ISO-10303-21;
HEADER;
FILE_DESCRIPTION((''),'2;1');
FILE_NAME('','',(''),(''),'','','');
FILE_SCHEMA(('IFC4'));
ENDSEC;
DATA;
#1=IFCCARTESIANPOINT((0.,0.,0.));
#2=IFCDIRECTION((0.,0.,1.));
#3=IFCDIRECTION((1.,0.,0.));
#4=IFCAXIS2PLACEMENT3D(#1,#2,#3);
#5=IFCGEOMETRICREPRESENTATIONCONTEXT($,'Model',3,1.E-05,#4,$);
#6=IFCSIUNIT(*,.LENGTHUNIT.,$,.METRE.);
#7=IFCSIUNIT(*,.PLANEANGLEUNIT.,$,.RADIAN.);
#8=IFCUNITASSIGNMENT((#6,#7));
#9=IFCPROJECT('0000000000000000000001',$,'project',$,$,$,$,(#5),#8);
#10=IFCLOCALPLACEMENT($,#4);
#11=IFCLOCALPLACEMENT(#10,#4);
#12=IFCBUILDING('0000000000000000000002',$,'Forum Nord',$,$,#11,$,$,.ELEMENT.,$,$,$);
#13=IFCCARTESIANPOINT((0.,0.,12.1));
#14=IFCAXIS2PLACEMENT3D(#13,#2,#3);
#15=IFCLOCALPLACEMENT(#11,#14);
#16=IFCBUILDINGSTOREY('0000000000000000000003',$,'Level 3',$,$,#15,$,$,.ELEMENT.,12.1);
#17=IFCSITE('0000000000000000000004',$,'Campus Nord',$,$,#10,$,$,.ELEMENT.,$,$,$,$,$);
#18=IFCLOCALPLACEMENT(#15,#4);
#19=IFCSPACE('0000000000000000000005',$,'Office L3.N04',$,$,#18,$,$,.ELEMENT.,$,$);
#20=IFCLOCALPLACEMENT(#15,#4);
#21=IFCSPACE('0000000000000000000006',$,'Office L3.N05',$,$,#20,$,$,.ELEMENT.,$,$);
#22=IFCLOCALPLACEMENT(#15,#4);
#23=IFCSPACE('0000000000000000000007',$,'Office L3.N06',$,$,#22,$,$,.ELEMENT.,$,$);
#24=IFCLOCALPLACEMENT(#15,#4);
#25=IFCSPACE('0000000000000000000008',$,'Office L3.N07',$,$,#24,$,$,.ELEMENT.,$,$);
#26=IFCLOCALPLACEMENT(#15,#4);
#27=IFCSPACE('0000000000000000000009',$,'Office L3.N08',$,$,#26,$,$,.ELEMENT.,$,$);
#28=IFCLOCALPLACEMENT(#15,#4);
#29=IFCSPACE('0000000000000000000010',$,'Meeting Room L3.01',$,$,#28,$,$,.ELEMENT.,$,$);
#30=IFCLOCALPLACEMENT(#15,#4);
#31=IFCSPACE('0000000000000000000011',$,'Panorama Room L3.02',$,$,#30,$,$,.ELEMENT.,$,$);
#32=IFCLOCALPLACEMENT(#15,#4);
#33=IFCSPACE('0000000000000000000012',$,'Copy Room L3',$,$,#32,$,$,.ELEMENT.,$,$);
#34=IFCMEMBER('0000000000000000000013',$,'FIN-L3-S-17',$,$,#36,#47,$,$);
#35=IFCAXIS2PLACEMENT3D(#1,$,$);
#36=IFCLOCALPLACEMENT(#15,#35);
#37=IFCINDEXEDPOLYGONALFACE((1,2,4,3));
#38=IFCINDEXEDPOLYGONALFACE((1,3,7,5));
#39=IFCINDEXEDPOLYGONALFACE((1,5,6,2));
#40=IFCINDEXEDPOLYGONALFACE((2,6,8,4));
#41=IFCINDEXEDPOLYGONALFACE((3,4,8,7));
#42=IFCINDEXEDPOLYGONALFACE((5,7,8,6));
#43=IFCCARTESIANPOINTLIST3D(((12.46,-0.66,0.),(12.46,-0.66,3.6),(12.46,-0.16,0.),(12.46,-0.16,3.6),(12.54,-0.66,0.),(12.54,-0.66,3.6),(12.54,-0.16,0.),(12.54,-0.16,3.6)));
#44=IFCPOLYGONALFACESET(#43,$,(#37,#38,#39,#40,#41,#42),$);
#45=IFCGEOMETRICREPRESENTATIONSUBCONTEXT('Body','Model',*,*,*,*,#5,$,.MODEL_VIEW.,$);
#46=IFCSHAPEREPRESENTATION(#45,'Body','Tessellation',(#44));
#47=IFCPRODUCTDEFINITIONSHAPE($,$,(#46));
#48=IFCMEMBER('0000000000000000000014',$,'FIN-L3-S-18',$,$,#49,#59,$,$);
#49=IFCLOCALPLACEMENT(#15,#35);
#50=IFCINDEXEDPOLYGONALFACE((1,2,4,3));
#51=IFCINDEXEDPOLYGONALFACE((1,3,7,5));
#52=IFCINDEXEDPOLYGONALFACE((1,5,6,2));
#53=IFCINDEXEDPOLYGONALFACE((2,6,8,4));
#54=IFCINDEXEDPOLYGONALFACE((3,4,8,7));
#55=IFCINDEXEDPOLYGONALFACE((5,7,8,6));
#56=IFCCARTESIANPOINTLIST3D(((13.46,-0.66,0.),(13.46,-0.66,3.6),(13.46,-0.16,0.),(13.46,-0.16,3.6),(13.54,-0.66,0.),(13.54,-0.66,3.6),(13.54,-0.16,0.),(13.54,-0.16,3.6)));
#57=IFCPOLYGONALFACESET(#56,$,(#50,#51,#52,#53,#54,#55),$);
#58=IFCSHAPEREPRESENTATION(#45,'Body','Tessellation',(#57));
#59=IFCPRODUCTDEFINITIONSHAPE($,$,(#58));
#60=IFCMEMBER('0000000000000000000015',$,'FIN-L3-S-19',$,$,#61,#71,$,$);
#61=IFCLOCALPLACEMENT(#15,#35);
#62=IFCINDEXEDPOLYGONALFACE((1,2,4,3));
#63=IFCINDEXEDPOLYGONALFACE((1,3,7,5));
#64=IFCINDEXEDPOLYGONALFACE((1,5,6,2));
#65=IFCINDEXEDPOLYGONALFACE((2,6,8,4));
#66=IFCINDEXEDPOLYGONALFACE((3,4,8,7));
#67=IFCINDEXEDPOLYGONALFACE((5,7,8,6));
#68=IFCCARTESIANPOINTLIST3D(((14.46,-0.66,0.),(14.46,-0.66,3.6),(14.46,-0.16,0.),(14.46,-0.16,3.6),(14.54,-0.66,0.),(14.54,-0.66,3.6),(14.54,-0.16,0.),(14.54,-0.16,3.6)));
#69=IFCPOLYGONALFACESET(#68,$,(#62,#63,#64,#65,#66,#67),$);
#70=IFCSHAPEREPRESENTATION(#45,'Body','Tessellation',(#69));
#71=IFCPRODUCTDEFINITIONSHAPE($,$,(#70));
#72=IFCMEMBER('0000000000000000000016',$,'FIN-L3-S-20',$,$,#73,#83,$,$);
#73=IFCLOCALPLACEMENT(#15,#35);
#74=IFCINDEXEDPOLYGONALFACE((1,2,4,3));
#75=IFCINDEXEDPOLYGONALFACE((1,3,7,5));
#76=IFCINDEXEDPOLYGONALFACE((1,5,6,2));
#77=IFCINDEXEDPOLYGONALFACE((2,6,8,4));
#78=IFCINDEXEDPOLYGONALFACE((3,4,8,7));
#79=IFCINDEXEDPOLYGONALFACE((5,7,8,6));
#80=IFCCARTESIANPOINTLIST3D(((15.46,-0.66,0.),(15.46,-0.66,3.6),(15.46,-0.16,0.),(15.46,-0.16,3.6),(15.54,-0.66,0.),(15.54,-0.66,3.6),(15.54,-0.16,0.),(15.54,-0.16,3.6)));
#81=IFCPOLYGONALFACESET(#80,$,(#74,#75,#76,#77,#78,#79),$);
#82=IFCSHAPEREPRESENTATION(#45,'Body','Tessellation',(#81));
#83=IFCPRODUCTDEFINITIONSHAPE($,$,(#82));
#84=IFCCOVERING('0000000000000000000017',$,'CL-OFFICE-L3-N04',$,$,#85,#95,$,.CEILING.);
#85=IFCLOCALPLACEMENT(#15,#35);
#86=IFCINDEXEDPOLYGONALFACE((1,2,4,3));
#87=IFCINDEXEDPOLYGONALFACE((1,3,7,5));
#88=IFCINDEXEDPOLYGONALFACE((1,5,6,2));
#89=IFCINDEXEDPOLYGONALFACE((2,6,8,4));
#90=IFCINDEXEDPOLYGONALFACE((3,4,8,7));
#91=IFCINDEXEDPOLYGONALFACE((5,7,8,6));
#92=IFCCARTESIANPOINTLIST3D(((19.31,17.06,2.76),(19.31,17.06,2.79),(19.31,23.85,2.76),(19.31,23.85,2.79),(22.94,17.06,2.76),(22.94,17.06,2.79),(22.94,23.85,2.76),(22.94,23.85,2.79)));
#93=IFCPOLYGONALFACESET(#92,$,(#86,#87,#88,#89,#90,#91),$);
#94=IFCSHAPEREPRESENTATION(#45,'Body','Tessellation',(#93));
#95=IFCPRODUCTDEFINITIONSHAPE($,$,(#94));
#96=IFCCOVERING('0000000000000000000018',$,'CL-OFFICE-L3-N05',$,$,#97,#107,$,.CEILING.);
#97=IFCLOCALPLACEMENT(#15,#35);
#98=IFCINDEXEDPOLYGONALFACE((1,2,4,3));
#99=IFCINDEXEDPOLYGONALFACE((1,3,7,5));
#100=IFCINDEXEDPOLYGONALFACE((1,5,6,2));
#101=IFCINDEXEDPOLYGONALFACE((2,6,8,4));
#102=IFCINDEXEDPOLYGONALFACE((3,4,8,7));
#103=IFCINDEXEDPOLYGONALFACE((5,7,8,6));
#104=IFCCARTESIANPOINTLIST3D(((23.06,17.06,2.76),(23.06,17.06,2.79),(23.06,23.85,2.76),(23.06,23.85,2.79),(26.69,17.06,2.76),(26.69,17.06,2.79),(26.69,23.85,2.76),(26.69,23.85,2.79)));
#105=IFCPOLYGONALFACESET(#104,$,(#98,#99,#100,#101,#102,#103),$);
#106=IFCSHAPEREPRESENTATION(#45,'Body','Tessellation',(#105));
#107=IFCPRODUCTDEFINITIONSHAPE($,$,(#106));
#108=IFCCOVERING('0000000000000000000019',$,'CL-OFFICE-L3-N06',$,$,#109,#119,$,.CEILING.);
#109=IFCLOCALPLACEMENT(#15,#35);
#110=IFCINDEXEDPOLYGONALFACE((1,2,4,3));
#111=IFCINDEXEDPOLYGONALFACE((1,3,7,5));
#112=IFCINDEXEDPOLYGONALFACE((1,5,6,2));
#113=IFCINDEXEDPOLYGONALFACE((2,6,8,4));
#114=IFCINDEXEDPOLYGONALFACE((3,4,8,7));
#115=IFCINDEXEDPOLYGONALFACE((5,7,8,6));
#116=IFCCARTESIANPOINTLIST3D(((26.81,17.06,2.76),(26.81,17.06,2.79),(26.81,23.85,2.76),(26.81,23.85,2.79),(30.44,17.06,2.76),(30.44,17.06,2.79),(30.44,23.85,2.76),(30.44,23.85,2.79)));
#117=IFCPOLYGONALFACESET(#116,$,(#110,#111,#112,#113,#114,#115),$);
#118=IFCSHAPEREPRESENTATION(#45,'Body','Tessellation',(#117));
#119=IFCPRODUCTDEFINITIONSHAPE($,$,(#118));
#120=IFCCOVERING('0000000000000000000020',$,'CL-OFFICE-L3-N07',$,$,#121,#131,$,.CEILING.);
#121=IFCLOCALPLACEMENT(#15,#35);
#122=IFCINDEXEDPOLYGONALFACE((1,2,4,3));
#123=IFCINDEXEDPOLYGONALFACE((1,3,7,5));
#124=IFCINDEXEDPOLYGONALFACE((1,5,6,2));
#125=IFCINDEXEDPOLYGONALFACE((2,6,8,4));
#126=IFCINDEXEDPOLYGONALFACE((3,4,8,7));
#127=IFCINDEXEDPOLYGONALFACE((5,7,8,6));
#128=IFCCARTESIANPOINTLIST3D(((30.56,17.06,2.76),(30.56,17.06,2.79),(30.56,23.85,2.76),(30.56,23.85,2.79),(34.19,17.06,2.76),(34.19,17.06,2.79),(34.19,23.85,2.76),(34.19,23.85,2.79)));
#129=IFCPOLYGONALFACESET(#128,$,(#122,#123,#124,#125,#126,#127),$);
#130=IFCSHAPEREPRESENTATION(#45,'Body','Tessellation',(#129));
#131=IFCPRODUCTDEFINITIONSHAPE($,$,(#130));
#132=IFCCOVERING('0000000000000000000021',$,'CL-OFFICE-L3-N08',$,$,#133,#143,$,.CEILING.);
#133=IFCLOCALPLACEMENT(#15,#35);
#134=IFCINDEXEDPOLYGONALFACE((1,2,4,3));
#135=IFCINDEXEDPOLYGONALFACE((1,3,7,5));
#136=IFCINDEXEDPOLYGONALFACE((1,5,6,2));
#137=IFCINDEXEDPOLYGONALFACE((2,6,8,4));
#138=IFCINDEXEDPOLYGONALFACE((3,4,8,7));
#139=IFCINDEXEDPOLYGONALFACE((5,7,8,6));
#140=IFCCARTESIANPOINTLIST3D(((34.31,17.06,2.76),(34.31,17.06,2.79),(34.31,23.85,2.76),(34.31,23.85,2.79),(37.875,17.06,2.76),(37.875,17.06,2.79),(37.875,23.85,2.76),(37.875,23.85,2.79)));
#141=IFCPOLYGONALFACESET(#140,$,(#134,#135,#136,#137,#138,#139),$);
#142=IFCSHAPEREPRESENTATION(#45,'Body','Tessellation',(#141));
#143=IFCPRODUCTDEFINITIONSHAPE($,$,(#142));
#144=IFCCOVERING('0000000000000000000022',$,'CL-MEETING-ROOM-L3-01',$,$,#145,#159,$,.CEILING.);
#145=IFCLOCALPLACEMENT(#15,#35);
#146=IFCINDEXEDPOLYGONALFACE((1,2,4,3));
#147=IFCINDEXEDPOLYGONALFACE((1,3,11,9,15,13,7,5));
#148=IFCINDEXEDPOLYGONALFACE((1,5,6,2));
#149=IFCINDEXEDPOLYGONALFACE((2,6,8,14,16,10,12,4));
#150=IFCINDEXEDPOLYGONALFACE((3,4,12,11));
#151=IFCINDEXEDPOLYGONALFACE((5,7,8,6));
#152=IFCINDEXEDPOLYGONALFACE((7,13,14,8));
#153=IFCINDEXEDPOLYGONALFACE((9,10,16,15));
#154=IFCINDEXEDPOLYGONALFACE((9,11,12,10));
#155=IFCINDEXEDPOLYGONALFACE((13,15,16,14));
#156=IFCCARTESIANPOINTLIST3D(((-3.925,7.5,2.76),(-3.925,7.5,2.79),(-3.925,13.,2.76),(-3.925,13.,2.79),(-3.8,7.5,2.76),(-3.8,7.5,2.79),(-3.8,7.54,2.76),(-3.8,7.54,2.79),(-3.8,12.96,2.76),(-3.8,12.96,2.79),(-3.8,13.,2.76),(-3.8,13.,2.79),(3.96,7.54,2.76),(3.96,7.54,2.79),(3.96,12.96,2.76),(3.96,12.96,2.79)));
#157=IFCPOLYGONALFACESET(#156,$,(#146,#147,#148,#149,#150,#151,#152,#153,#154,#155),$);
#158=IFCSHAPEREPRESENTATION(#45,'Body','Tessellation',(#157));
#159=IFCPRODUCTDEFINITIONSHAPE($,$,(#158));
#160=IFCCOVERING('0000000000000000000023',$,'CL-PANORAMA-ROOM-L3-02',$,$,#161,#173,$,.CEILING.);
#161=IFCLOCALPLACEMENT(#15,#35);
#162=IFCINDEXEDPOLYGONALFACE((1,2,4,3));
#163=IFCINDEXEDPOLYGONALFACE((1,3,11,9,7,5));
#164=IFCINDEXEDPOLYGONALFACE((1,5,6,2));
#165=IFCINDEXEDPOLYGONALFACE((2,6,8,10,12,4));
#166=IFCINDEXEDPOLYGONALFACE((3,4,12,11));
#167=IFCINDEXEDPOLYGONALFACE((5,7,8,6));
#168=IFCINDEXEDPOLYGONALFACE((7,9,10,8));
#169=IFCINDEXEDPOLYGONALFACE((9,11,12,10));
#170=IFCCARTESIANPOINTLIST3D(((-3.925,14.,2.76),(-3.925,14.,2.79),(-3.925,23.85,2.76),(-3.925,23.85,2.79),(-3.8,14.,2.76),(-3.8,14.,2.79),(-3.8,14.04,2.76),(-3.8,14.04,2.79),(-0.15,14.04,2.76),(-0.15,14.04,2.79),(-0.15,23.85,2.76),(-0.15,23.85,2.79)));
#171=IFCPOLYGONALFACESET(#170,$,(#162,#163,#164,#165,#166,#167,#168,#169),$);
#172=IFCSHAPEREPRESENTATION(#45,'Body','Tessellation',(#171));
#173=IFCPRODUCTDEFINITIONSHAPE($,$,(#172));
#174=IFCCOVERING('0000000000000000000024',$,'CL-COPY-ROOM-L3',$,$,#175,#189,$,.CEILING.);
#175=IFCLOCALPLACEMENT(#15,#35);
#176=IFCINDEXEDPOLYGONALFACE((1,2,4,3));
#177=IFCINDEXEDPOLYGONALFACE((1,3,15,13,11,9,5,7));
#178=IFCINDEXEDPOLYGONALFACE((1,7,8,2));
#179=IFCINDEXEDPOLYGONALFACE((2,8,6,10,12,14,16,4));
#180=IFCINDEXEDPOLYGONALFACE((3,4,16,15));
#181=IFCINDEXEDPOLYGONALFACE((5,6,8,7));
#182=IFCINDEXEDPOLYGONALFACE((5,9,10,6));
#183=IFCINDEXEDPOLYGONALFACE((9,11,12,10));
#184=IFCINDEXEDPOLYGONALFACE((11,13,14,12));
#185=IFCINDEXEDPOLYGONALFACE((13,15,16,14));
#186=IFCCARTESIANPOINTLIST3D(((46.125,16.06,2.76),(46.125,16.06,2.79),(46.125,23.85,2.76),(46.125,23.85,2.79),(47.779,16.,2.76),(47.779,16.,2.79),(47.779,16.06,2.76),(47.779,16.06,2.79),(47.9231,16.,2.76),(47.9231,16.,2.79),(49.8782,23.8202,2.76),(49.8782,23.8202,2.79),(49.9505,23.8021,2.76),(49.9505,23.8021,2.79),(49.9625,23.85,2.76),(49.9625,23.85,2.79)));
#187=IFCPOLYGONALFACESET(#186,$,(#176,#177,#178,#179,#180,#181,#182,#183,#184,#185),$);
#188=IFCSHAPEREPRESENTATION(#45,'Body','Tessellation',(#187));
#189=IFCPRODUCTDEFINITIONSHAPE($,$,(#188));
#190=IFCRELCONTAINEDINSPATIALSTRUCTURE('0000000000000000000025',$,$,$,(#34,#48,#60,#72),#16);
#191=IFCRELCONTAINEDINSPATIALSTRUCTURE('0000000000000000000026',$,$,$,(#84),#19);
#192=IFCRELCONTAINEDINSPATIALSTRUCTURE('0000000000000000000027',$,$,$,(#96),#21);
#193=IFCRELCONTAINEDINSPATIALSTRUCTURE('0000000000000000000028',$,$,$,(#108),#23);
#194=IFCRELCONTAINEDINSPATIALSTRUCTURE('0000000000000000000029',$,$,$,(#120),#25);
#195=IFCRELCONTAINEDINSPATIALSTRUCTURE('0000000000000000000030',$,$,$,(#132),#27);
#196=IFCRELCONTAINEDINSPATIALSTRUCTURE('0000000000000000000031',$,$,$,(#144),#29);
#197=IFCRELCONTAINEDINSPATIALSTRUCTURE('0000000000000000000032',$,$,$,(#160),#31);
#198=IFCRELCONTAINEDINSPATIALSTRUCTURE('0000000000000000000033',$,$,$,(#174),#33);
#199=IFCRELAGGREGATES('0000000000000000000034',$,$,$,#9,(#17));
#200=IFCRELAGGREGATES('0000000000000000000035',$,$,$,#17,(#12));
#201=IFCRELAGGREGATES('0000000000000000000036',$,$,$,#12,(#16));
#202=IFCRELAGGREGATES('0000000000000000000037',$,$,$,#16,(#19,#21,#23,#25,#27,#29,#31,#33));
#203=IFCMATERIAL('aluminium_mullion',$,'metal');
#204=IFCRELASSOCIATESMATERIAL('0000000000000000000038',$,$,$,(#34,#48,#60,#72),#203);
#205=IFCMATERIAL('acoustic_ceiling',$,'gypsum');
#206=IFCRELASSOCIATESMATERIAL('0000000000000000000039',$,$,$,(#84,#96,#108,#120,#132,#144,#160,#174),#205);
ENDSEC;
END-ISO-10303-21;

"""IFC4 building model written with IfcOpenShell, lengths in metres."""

from ifc_helpers import new_model, si_unit, frame, origin_with_axes, place, context, subcontext, project, spatial, polyline, outline, extrude, material, element, save


model = new_model("IFC4")

# Units and contexts
model_context = context("Model", 3, precision=1e-05, world=origin_with_axes())
body_context = subcontext(model_context, "Body", "Model", "MODEL_VIEW")
ifc_project = project(units=[si_unit("LENGTHUNIT", "METRE"), si_unit("PLANEANGLEUNIT", "RADIAN")], contexts=[model_context])

# Site, building, storey
site_placement = place(None, origin_with_axes())
site = spatial("IfcSite", under=ifc_project, at=site_placement, Name="Campus Nord", CompositionType="ELEMENT")
building_placement = place(site_placement, origin_with_axes())
building = spatial("IfcBuilding", under=site, at=building_placement, Name="Forum Nord", CompositionType="ELEMENT")
storey_placement = place(building_placement, frame((0.0, 0.0, 12.1), z_axis=(0.0, 0.0, 1.0), x_axis=(1.0, 0.0, 0.0)))
storey = spatial("IfcBuildingStorey", under=building, at=storey_placement, Name="Level 3", CompositionType="ELEMENT", Elevation=12.1)

# Members
ifc_material_1 = material(Name="aluminium_mullion", Category="metal")
member_1_placement = place(storey_placement, origin_with_axes())
element("IfcMember", 1, at=member_1_placement, inside=storey, material=ifc_material_1, Name="FIN-L3-S-17", context=body_context, shape_type="SweptSolid", body=[
    extrude(outline(polyline([(12.46, -0.66), (12.54, -0.66), (12.54, -0.16), (12.46, -0.16), (12.46, -0.66)])), origin_with_axes(), (0.0, 0.0, 1.0), 3.6),
])
member_2_placement = place(storey_placement, origin_with_axes())
element("IfcMember", 2, at=member_2_placement, inside=storey, material=ifc_material_1, Name="FIN-L3-S-18", context=body_context, shape_type="SweptSolid", body=[
    extrude(outline(polyline([(13.46, -0.66), (13.54, -0.66), (13.54, -0.16), (13.46, -0.16), (13.46, -0.66)])), origin_with_axes(), (0.0, 0.0, 1.0), 3.6),
])
member_3_placement = place(storey_placement, origin_with_axes())
element("IfcMember", 3, at=member_3_placement, inside=storey, material=ifc_material_1, Name="FIN-L3-S-19", context=body_context, shape_type="SweptSolid", body=[
    extrude(outline(polyline([(14.46, -0.66), (14.54, -0.66), (14.54, -0.16), (14.46, -0.16), (14.46, -0.66)])), origin_with_axes(), (0.0, 0.0, 1.0), 3.6),
])
member_4_placement = place(storey_placement, origin_with_axes())
element("IfcMember", 4, at=member_4_placement, inside=storey, material=ifc_material_1, Name="FIN-L3-S-20", context=body_context, shape_type="SweptSolid", body=[
    extrude(outline(polyline([(15.46, -0.66), (15.54, -0.66), (15.54, -0.16), (15.46, -0.16), (15.46, -0.66)])), origin_with_axes(), (0.0, 0.0, 1.0), 3.6),
])

# Shared definitions
space_1_placement = place(storey_placement, origin_with_axes())
space_1 = spatial("IfcSpace", under=storey, at=space_1_placement, Name="Office L3.N04", CompositionType="ELEMENT")

# Covering
ifc_material_2 = material(Name="acoustic_ceiling", Category="gypsum")
covering_1_placement = place(storey_placement, frame((0.0, 0.0, 2.76), z_axis=(0.0, 0.0, 1.0), x_axis=(1.0, 0.0, 0.0)))
element("IfcCovering", 5, at=covering_1_placement, inside=space_1, material=ifc_material_2, Name="CL-OFFICE-L3-N04", PredefinedType="CEILING", context=body_context, shape_type="SweptSolid", body=[
    extrude(outline(polyline([(19.31, 23.85), (19.31, 17.06), (22.94, 17.06), (22.94, 23.85), (19.31, 23.85)])), origin_with_axes(), (0.0, 0.0, 1.0), 0.03),
])

# Shared definitions
space_2_placement = place(storey_placement, origin_with_axes())
space_2 = spatial("IfcSpace", under=storey, at=space_2_placement, Name="Office L3.N05", CompositionType="ELEMENT")

# Covering
covering_2_placement = place(storey_placement, frame((0.0, 0.0, 2.76), z_axis=(0.0, 0.0, 1.0), x_axis=(1.0, 0.0, 0.0)))
element("IfcCovering", 6, at=covering_2_placement, inside=space_2, material=ifc_material_2, Name="CL-OFFICE-L3-N05", PredefinedType="CEILING", context=body_context, shape_type="SweptSolid", body=[
    extrude(outline(polyline([(23.06, 23.85), (23.06, 17.06), (26.69, 17.06), (26.69, 23.85), (23.06, 23.85)])), origin_with_axes(), (0.0, 0.0, 1.0), 0.03),
])

# Shared definitions
space_3_placement = place(storey_placement, origin_with_axes())
space_3 = spatial("IfcSpace", under=storey, at=space_3_placement, Name="Office L3.N06", CompositionType="ELEMENT")

# Covering
covering_3_placement = place(storey_placement, frame((0.0, 0.0, 2.76), z_axis=(0.0, 0.0, 1.0), x_axis=(1.0, 0.0, 0.0)))
element("IfcCovering", 7, at=covering_3_placement, inside=space_3, material=ifc_material_2, Name="CL-OFFICE-L3-N06", PredefinedType="CEILING", context=body_context, shape_type="SweptSolid", body=[
    extrude(outline(polyline([(26.81, 23.85), (26.81, 17.06), (30.44, 17.06), (30.44, 23.85), (26.81, 23.85)])), origin_with_axes(), (0.0, 0.0, 1.0), 0.03),
])

# Shared definitions
space_4_placement = place(storey_placement, origin_with_axes())
space_4 = spatial("IfcSpace", under=storey, at=space_4_placement, Name="Office L3.N07", CompositionType="ELEMENT")

# Covering
covering_4_placement = place(storey_placement, frame((0.0, 0.0, 2.76), z_axis=(0.0, 0.0, 1.0), x_axis=(1.0, 0.0, 0.0)))
element("IfcCovering", 8, at=covering_4_placement, inside=space_4, material=ifc_material_2, Name="CL-OFFICE-L3-N07", PredefinedType="CEILING", context=body_context, shape_type="SweptSolid", body=[
    extrude(outline(polyline([(30.56, 23.85), (30.56, 17.06), (34.19, 17.06), (34.19, 23.85), (30.56, 23.85)])), origin_with_axes(), (0.0, 0.0, 1.0), 0.03),
])

# Shared definitions
space_5_placement = place(storey_placement, origin_with_axes())
space_5 = spatial("IfcSpace", under=storey, at=space_5_placement, Name="Office L3.N08", CompositionType="ELEMENT")

# Covering
covering_5_placement = place(storey_placement, frame((0.0, 0.0, 2.76), z_axis=(0.0, 0.0, 1.0), x_axis=(1.0, 0.0, 0.0)))
element("IfcCovering", 9, at=covering_5_placement, inside=space_5, material=ifc_material_2, Name="CL-OFFICE-L3-N08", PredefinedType="CEILING", context=body_context, shape_type="SweptSolid", body=[
    extrude(outline(polyline([(34.31, 23.85), (34.31, 17.06), (37.875, 17.06), (37.875, 23.85), (34.31, 23.85)])), origin_with_axes(), (0.0, 0.0, 1.0), 0.03),
])

# Shared definitions
space_6_placement = place(storey_placement, origin_with_axes())
space_6 = spatial("IfcSpace", under=storey, at=space_6_placement, Name="Meeting Room L3.01", CompositionType="ELEMENT")

# Covering
covering_6_placement = place(storey_placement, frame((0.0, 0.0, 2.76), z_axis=(0.0, 0.0, 1.0), x_axis=(1.0, 0.0, 0.0)))
element("IfcCovering", 10, at=covering_6_placement, inside=space_6, material=ifc_material_2, Name="CL-MEETING-ROOM-L3-01", PredefinedType="CEILING", context=body_context, shape_type="SweptSolid", body=[
    extrude(outline(polyline([(-3.925, 13.0), (-3.925, 7.5), (-3.8, 7.5), (-3.8, 7.54), (3.96, 7.54), (3.96, 12.96), (-3.8, 12.96), (-3.8, 13.0), (-3.925, 13.0)])), origin_with_axes(), (0.0, 0.0, 1.0), 0.03),
])

# Shared definitions
space_7_placement = place(storey_placement, origin_with_axes())
space_7 = spatial("IfcSpace", under=storey, at=space_7_placement, Name="Panorama Room L3.02", CompositionType="ELEMENT")

# Covering
covering_7_placement = place(storey_placement, frame((0.0, 0.0, 2.76), z_axis=(0.0, 0.0, 1.0), x_axis=(1.0, 0.0, 0.0)))
element("IfcCovering", 11, at=covering_7_placement, inside=space_7, material=ifc_material_2, Name="CL-PANORAMA-ROOM-L3-02", PredefinedType="CEILING", context=body_context, shape_type="SweptSolid", body=[
    extrude(outline(polyline([(-3.925, 23.85), (-3.925, 14.0), (-3.8, 14.0), (-3.8, 14.04), (-0.15, 14.04), (-0.15, 23.85), (-3.925, 23.85)])), origin_with_axes(), (0.0, 0.0, 1.0), 0.03),
])

# Shared definitions
space_8_placement = place(storey_placement, origin_with_axes())
space_8 = spatial("IfcSpace", under=storey, at=space_8_placement, Name="Copy Room L3", CompositionType="ELEMENT")

# Covering
covering_8_placement = place(storey_placement, frame((0.0, 0.0, 2.76), z_axis=(0.0, 0.0, 1.0), x_axis=(1.0, 0.0, 0.0)))
element("IfcCovering", 12, at=covering_8_placement, inside=space_8, material=ifc_material_2, Name="CL-COPY-ROOM-L3", PredefinedType="CEILING", context=body_context, shape_type="SweptSolid", body=[
    extrude(outline(polyline([(46.125, 16.06), (47.779, 16.06), (47.779, 16.0), (47.9231, 16.0), (49.8782, 23.8202), (49.9505, 23.8021), (49.9625, 23.85), (46.125, 23.85), (46.125, 16.06)])), origin_with_axes(), (0.0, 0.0, 1.0), 0.03),
])

save(model, "model.ifc")
